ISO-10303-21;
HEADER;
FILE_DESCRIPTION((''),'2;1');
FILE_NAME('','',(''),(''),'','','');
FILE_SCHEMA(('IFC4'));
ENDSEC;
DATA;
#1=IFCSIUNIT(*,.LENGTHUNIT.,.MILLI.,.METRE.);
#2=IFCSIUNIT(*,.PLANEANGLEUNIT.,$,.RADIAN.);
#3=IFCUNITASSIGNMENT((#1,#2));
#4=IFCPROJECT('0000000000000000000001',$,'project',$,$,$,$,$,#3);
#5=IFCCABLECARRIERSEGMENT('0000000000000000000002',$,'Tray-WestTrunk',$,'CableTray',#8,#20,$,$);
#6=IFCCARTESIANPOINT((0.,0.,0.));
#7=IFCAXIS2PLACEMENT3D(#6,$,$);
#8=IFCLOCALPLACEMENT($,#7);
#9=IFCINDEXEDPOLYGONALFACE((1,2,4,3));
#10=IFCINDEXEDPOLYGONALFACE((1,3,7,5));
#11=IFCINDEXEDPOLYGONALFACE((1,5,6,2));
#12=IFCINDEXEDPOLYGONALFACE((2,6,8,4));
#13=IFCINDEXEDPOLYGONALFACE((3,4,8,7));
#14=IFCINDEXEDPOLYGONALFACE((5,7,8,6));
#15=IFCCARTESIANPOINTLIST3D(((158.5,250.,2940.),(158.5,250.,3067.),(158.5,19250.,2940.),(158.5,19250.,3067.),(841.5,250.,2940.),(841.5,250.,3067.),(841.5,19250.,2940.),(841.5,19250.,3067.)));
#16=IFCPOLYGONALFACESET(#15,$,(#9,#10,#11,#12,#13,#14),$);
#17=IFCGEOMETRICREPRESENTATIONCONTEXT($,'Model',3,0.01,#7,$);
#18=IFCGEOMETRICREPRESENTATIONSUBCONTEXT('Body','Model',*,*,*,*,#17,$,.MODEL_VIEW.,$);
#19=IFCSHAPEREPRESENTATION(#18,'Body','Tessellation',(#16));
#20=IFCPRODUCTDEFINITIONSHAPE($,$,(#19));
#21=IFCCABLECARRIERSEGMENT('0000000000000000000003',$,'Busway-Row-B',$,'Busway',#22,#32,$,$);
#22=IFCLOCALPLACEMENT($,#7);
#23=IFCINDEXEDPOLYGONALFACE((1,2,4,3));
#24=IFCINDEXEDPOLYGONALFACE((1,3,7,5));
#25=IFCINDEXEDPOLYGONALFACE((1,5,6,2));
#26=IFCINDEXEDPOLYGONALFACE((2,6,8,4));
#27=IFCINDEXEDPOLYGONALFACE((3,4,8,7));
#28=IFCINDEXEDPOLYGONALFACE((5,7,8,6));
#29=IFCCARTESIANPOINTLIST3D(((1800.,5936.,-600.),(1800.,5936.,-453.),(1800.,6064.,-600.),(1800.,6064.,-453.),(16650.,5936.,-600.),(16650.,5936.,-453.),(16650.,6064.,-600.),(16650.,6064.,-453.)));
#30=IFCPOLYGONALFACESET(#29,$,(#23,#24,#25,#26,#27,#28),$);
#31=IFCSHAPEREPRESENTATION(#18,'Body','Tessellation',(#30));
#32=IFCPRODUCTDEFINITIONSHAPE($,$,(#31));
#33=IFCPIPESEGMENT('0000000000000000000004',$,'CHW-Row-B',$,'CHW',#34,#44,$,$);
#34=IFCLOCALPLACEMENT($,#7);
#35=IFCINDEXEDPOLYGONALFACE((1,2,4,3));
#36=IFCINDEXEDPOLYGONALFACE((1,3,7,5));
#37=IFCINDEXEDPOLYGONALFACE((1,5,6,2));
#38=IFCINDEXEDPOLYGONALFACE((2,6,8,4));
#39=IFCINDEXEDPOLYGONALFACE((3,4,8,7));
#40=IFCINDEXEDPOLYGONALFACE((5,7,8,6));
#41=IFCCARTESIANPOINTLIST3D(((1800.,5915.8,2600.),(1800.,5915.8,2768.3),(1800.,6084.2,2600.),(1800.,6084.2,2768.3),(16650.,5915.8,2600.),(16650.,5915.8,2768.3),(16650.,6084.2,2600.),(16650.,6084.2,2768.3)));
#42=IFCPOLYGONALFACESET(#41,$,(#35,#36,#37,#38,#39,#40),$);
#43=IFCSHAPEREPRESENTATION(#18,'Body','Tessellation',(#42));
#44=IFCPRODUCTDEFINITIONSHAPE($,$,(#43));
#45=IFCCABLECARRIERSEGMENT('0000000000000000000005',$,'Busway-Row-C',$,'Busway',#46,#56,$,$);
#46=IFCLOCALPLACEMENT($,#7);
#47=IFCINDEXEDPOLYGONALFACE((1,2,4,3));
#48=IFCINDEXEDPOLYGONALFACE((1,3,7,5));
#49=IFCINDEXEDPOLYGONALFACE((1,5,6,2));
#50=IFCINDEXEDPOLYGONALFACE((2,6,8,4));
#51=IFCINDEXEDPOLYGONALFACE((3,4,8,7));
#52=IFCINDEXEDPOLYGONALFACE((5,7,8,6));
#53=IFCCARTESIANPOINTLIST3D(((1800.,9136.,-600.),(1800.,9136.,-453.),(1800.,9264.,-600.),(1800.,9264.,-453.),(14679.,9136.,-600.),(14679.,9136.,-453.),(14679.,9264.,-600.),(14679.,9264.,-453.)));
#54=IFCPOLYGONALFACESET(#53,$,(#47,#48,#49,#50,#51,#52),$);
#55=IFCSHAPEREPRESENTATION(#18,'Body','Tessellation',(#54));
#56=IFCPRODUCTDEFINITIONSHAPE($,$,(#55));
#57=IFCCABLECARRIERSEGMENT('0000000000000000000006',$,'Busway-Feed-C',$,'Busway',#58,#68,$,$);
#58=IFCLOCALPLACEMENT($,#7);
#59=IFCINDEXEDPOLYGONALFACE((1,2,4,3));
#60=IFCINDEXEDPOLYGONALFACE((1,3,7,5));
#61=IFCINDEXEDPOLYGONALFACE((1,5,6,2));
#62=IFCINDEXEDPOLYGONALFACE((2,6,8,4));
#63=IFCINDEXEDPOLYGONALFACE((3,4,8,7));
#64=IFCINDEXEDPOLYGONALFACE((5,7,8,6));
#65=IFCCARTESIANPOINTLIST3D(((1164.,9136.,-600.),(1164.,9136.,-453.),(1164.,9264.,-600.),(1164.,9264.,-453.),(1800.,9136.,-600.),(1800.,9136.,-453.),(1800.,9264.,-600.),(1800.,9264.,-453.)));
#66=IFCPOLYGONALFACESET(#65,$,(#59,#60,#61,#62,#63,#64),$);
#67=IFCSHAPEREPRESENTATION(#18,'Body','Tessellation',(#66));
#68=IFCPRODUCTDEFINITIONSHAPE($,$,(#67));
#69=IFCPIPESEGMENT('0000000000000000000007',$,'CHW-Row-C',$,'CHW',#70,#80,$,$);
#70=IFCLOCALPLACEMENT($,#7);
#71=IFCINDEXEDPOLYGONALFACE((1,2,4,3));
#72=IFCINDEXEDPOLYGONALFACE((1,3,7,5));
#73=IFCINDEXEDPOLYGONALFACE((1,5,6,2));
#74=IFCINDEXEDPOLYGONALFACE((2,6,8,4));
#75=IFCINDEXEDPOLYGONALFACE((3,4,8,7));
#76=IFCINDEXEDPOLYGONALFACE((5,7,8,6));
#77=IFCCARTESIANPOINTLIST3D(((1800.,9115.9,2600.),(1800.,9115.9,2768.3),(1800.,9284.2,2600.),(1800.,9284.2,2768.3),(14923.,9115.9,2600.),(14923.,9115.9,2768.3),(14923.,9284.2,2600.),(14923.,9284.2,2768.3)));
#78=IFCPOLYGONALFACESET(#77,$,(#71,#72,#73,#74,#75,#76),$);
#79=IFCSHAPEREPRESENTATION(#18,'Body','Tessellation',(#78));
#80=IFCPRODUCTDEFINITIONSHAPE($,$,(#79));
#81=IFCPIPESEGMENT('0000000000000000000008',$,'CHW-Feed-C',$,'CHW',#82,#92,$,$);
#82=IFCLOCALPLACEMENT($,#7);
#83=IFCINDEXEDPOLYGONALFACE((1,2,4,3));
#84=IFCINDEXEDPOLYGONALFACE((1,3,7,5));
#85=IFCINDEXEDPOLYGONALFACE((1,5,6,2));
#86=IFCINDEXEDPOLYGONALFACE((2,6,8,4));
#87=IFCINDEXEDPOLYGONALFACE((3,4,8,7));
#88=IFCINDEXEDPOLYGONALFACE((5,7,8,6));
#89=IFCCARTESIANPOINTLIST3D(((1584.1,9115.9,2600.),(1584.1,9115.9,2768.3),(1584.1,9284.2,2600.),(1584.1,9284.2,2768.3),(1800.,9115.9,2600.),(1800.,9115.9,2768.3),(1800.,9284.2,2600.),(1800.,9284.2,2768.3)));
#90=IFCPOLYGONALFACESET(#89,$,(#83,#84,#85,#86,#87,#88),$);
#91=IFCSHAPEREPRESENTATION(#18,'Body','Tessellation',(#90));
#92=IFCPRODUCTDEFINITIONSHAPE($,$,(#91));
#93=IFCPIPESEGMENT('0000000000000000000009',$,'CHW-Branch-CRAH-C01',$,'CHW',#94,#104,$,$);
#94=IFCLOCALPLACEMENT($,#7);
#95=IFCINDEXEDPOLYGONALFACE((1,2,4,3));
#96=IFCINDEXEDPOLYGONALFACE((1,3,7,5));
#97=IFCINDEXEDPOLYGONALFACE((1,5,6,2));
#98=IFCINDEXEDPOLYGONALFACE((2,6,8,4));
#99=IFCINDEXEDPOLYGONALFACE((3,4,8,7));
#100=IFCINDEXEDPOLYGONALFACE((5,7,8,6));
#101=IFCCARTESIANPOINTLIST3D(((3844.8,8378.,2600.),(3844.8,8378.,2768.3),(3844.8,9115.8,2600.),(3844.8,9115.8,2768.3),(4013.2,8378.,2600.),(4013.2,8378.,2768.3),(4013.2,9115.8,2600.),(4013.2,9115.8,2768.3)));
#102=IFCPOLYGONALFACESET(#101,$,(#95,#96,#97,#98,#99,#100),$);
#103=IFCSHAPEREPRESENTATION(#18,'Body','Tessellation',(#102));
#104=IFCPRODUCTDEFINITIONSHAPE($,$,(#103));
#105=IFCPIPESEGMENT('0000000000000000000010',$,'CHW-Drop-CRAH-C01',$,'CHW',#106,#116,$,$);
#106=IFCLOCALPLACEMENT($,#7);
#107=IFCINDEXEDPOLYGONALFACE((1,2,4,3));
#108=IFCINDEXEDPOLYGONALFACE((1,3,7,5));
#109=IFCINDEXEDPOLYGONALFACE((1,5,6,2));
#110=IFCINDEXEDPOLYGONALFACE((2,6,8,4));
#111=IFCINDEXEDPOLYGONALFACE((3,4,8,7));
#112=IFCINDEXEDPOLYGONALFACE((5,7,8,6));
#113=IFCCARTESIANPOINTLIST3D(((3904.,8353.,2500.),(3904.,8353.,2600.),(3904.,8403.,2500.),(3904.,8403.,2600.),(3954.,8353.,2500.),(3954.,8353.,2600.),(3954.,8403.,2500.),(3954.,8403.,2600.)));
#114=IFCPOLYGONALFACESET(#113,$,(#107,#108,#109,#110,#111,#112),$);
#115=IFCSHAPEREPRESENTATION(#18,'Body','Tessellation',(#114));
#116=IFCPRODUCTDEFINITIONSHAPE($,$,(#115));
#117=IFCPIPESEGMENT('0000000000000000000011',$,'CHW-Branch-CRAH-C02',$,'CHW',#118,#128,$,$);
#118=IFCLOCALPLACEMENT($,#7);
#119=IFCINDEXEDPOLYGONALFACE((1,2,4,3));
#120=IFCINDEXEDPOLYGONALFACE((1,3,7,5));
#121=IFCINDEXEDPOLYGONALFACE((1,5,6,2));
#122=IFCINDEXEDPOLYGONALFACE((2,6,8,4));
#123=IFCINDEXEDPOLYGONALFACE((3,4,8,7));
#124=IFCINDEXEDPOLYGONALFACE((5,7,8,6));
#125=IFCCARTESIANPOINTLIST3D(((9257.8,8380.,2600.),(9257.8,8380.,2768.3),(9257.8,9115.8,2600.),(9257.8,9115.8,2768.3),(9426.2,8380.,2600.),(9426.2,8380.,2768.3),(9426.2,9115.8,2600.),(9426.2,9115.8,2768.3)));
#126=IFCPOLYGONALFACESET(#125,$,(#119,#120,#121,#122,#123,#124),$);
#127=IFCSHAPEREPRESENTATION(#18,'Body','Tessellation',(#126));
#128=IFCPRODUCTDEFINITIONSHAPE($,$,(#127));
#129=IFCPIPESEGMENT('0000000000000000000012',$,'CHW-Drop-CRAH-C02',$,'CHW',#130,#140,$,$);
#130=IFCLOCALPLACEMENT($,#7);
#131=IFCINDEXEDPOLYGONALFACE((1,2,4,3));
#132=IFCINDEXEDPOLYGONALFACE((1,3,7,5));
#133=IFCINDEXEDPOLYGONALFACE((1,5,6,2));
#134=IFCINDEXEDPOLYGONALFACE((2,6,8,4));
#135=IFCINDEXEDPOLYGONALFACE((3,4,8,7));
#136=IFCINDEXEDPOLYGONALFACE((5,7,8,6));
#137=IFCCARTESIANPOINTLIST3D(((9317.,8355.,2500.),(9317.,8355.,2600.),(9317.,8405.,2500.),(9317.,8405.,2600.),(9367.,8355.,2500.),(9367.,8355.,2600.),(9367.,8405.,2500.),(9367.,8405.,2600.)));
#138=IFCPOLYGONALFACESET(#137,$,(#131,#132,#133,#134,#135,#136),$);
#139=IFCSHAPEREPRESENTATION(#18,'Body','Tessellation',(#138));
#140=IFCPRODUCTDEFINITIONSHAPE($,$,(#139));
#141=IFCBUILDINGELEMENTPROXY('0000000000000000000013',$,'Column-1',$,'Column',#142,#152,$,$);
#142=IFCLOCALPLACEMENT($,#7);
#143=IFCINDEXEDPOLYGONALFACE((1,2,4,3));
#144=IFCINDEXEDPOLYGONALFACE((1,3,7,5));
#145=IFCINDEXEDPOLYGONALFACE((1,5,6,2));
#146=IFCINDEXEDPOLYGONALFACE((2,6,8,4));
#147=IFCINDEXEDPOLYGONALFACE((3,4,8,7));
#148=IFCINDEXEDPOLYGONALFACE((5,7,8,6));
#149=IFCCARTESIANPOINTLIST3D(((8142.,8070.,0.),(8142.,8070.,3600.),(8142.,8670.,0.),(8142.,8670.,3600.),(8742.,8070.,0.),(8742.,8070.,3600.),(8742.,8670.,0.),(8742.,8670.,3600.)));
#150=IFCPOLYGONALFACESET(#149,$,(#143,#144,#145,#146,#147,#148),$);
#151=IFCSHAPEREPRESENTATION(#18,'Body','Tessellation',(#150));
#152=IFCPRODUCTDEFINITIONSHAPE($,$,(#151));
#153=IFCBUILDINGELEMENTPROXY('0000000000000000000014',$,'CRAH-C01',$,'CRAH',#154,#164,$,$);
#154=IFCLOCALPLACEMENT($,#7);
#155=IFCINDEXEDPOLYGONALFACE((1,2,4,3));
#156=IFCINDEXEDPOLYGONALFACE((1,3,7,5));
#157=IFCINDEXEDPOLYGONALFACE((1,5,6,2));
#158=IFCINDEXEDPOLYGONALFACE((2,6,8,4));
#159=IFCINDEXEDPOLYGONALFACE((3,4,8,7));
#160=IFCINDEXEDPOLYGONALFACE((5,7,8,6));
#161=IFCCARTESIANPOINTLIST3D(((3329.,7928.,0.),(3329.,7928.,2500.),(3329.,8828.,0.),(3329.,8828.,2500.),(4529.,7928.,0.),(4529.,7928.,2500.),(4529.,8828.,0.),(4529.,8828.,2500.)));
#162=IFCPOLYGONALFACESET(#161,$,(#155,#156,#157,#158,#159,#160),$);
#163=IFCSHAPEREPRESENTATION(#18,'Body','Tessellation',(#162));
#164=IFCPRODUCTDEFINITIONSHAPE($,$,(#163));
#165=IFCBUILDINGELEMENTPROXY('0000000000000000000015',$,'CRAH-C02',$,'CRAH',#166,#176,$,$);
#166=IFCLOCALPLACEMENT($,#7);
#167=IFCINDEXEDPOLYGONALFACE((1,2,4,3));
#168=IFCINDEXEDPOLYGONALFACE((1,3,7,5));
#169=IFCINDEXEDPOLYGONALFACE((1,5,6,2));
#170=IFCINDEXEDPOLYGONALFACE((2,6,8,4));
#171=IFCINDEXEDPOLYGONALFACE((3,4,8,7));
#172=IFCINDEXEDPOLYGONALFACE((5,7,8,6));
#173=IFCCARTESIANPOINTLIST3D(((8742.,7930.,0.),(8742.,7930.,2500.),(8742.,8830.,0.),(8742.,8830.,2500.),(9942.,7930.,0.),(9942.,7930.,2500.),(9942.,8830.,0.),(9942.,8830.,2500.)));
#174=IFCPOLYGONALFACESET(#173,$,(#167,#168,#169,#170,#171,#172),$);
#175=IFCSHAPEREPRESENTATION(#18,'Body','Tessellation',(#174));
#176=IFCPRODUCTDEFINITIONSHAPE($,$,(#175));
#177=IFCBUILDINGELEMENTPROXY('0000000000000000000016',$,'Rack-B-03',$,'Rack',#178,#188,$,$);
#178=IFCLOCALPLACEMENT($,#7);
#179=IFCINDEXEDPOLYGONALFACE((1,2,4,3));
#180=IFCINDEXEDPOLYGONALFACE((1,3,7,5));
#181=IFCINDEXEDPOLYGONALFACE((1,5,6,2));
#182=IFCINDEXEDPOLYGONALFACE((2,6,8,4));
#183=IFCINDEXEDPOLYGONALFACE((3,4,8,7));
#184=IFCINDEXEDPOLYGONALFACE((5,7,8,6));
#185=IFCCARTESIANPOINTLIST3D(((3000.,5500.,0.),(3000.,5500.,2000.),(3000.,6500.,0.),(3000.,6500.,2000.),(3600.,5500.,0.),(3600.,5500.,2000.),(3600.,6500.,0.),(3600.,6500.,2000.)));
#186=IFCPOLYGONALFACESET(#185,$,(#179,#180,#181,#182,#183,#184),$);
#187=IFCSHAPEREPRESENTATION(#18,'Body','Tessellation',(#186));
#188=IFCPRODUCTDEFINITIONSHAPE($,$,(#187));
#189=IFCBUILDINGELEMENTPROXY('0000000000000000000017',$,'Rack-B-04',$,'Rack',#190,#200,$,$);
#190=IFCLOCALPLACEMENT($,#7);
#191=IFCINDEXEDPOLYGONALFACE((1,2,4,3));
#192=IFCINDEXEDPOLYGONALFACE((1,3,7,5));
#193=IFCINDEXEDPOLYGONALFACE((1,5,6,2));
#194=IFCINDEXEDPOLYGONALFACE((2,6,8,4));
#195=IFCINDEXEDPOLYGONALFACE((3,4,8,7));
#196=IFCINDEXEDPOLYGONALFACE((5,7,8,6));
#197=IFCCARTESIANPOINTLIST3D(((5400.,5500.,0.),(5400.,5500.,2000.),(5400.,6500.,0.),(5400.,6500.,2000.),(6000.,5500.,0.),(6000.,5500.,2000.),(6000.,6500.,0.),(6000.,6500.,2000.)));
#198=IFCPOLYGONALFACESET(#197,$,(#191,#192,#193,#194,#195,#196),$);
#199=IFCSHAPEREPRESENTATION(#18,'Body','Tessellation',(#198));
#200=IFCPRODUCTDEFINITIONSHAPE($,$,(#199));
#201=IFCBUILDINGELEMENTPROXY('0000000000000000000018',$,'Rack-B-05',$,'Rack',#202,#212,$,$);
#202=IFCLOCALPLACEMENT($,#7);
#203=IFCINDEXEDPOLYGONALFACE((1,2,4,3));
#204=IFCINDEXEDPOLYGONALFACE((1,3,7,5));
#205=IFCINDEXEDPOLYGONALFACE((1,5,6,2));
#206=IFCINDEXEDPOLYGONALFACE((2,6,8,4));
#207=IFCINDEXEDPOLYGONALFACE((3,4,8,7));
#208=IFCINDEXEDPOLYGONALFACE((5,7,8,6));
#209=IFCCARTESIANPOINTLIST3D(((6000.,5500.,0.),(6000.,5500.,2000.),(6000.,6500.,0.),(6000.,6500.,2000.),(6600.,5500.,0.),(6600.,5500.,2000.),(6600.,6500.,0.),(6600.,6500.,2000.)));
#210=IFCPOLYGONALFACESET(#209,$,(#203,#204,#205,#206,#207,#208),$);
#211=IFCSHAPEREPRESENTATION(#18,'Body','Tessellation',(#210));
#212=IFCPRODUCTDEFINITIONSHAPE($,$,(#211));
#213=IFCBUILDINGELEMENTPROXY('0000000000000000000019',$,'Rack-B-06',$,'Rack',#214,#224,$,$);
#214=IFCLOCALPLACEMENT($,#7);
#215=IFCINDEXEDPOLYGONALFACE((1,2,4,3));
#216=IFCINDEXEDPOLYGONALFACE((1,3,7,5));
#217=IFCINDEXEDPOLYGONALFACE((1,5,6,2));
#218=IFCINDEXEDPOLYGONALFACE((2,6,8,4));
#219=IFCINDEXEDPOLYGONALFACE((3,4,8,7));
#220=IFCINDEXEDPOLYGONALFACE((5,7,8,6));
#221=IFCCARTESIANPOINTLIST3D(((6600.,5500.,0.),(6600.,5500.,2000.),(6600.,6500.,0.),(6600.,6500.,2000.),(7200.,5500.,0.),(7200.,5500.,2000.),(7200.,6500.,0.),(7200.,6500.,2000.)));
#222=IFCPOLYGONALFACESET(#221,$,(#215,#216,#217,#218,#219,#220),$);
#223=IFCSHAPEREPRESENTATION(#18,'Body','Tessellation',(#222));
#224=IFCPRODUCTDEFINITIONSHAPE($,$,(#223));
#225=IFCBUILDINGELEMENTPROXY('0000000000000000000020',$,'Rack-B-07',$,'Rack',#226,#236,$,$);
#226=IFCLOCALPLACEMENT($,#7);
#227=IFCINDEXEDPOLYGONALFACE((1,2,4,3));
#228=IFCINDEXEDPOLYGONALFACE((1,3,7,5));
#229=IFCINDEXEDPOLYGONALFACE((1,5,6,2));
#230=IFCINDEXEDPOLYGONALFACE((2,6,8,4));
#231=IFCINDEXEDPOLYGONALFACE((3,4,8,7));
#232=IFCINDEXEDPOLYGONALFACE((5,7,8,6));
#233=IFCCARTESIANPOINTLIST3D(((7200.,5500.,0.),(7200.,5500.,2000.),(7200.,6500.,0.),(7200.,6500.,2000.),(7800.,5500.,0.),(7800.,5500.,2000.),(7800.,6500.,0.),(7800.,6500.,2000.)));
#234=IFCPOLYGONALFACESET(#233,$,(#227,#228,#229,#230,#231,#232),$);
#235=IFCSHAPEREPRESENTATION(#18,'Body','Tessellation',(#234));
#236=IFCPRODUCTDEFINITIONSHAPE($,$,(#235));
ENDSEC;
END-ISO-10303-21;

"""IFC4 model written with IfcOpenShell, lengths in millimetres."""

from ifc_helpers import new_model, si_unit, frame, origin, place, context, subcontext, project, rectangle, extrude, element, save


model = new_model("IFC4")

# Units and contexts
model_context = context("Model", 3, precision=0.01, world=origin())
body_context = subcontext(model_context, "Body", "Model", "MODEL_VIEW")
ifc_project = project(units=[si_unit("LENGTHUNIT", "METRE", prefix="MILLI"), si_unit("PLANEANGLEUNIT", "RADIAN")])

# Cable carrier segments
placement = place(None, origin())
cable_carrier_segment_1_placement = place(placement, frame((500.0, 9750.0, 2940.0)))
element("IfcCableCarrierSegment", 1, at=cable_carrier_segment_1_placement, Name="Tray-WestTrunk", ObjectType="CableTray", context=body_context, shape_type="SweptSolid", body=[
    extrude(rectangle(XDim=683.0, YDim=19000.0), origin(), (0.0, 0.0, 1.0), 127.0),
])
cable_carrier_segment_2_placement = place(placement, frame((9225.0, 6000.0, -600.0)))
element("IfcCableCarrierSegment", 2, at=cable_carrier_segment_2_placement, Name="Busway-Row-B", ObjectType="Busway", context=body_context, shape_type="SweptSolid", body=[
    extrude(rectangle(XDim=14850.0, YDim=128.0), origin(), (0.0, 0.0, 1.0), 147.0),
])

# Pipe segment
pipe_segment_1_placement = place(placement, frame((9225.0, 6000.0, 2600.0)))
element("IfcPipeSegment", 3, at=pipe_segment_1_placement, Name="CHW-Row-B", ObjectType="CHW", context=body_context, shape_type="SweptSolid", body=[
    extrude(rectangle(XDim=14850.0, YDim=168.3), origin(), (0.0, 0.0, 1.0), 168.3),
])

# Cable carrier segments
cable_carrier_segment_3_placement = place(placement, frame((8239.5, 9200.0, -600.0)))
element("IfcCableCarrierSegment", 4, at=cable_carrier_segment_3_placement, Name="Busway-Row-C", ObjectType="Busway", context=body_context, shape_type="SweptSolid", body=[
    extrude(rectangle(XDim=12879.0, YDim=128.0), origin(), (0.0, 0.0, 1.0), 147.0),
])
cable_carrier_segment_4_placement = place(placement, frame((1482.0, 9200.0, -600.0)))
element("IfcCableCarrierSegment", 5, at=cable_carrier_segment_4_placement, Name="Busway-Feed-C", ObjectType="Busway", context=body_context, shape_type="SweptSolid", body=[
    extrude(rectangle(XDim=636.0, YDim=128.0), origin(), (0.0, 0.0, 1.0), 147.0),
])

# Pipe segments
pipe_segment_2_placement = place(placement, frame((8361.5, 9200.0, 2600.0)))
element("IfcPipeSegment", 6, at=pipe_segment_2_placement, Name="CHW-Row-C", ObjectType="CHW", context=body_context, shape_type="SweptSolid", body=[
    extrude(rectangle(XDim=13123.0, YDim=168.3), origin(), (0.0, 0.0, 1.0), 168.3),
])
pipe_segment_3_placement = place(placement, frame((1692.1, 9200.0, 2600.0)))
element("IfcPipeSegment", 7, at=pipe_segment_3_placement, Name="CHW-Feed-C", ObjectType="CHW", context=body_context, shape_type="SweptSolid", body=[
    extrude(rectangle(XDim=215.8, YDim=168.3), origin(), (0.0, 0.0, 1.0), 168.3),
])
pipe_segment_4_placement = place(placement, frame((3929.0, 8746.9, 2600.0)))
element("IfcPipeSegment", 8, at=pipe_segment_4_placement, Name="CHW-Branch-CRAH-C01", ObjectType="CHW", context=body_context, shape_type="SweptSolid", body=[
    extrude(rectangle(XDim=168.3, YDim=737.9), origin(), (0.0, 0.0, 1.0), 168.3),
])
pipe_segment_5_placement = place(placement, frame((3929.0, 8378.0, 2500.0)))
element("IfcPipeSegment", 9, at=pipe_segment_5_placement, Name="CHW-Drop-CRAH-C01", ObjectType="CHW", context=body_context, shape_type="SweptSolid", body=[
    extrude(rectangle(XDim=50.0, YDim=50.0), origin(), (0.0, 0.0, 1.0), 100.0),
])
pipe_segment_6_placement = place(placement, frame((9342.0, 8747.9, 2600.0)))
element("IfcPipeSegment", 10, at=pipe_segment_6_placement, Name="CHW-Branch-CRAH-C02", ObjectType="CHW", context=body_context, shape_type="SweptSolid", body=[
    extrude(rectangle(XDim=168.3, YDim=735.9), origin(), (0.0, 0.0, 1.0), 168.3),
])
pipe_segment_7_placement = place(placement, frame((9342.0, 8380.0, 2500.0)))
element("IfcPipeSegment", 11, at=pipe_segment_7_placement, Name="CHW-Drop-CRAH-C02", ObjectType="CHW", context=body_context, shape_type="SweptSolid", body=[
    extrude(rectangle(XDim=50.0, YDim=50.0), origin(), (0.0, 0.0, 1.0), 100.0),
])

# Building element proxies
proxy_placement = place(placement, frame((8442.0, 8370.0, 0.0)))
element("IfcBuildingElementProxy", 12, at=proxy_placement, Name="Column-1", ObjectType="Column", context=body_context, shape_type="SweptSolid", body=[
    extrude(rectangle(XDim=600.0, YDim=600.0), origin(), (0.0, 0.0, 1.0), 3600.0),
])
for number, where, name in (
    (13, (3929.0, 8378.0, 0.0), "CRAH-C01"),
    (14, (9342.0, 8380.0, 0.0), "CRAH-C02"),
):
    element("IfcBuildingElementProxy", number, at=place(placement, frame(where)), Name=name, ObjectType="CRAH", context=body_context, shape_type="SweptSolid", body=[
        extrude(rectangle(XDim=1200.0, YDim=900.0), origin(), (0.0, 0.0, 1.0), 2500.0),
    ])
for number, where, name in (
    (15, (3300.0, 6000.0, 0.0), "Rack-B-03"),
    (16, (5700.0, 6000.0, 0.0), "Rack-B-04"),
    (17, (6300.0, 6000.0, 0.0), "Rack-B-05"),
    (18, (6900.0, 6000.0, 0.0), "Rack-B-06"),
    (19, (7500.0, 6000.0, 0.0), "Rack-B-07"),
):
    element("IfcBuildingElementProxy", number, at=place(placement, frame(where)), Name=name, ObjectType="Rack", context=body_context, shape_type="SweptSolid", body=[
        extrude(rectangle(XDim=600.0, YDim=1000.0), origin(), (0.0, 0.0, 1.0), 2000.0),
    ])

save(model, "model.ifc")
